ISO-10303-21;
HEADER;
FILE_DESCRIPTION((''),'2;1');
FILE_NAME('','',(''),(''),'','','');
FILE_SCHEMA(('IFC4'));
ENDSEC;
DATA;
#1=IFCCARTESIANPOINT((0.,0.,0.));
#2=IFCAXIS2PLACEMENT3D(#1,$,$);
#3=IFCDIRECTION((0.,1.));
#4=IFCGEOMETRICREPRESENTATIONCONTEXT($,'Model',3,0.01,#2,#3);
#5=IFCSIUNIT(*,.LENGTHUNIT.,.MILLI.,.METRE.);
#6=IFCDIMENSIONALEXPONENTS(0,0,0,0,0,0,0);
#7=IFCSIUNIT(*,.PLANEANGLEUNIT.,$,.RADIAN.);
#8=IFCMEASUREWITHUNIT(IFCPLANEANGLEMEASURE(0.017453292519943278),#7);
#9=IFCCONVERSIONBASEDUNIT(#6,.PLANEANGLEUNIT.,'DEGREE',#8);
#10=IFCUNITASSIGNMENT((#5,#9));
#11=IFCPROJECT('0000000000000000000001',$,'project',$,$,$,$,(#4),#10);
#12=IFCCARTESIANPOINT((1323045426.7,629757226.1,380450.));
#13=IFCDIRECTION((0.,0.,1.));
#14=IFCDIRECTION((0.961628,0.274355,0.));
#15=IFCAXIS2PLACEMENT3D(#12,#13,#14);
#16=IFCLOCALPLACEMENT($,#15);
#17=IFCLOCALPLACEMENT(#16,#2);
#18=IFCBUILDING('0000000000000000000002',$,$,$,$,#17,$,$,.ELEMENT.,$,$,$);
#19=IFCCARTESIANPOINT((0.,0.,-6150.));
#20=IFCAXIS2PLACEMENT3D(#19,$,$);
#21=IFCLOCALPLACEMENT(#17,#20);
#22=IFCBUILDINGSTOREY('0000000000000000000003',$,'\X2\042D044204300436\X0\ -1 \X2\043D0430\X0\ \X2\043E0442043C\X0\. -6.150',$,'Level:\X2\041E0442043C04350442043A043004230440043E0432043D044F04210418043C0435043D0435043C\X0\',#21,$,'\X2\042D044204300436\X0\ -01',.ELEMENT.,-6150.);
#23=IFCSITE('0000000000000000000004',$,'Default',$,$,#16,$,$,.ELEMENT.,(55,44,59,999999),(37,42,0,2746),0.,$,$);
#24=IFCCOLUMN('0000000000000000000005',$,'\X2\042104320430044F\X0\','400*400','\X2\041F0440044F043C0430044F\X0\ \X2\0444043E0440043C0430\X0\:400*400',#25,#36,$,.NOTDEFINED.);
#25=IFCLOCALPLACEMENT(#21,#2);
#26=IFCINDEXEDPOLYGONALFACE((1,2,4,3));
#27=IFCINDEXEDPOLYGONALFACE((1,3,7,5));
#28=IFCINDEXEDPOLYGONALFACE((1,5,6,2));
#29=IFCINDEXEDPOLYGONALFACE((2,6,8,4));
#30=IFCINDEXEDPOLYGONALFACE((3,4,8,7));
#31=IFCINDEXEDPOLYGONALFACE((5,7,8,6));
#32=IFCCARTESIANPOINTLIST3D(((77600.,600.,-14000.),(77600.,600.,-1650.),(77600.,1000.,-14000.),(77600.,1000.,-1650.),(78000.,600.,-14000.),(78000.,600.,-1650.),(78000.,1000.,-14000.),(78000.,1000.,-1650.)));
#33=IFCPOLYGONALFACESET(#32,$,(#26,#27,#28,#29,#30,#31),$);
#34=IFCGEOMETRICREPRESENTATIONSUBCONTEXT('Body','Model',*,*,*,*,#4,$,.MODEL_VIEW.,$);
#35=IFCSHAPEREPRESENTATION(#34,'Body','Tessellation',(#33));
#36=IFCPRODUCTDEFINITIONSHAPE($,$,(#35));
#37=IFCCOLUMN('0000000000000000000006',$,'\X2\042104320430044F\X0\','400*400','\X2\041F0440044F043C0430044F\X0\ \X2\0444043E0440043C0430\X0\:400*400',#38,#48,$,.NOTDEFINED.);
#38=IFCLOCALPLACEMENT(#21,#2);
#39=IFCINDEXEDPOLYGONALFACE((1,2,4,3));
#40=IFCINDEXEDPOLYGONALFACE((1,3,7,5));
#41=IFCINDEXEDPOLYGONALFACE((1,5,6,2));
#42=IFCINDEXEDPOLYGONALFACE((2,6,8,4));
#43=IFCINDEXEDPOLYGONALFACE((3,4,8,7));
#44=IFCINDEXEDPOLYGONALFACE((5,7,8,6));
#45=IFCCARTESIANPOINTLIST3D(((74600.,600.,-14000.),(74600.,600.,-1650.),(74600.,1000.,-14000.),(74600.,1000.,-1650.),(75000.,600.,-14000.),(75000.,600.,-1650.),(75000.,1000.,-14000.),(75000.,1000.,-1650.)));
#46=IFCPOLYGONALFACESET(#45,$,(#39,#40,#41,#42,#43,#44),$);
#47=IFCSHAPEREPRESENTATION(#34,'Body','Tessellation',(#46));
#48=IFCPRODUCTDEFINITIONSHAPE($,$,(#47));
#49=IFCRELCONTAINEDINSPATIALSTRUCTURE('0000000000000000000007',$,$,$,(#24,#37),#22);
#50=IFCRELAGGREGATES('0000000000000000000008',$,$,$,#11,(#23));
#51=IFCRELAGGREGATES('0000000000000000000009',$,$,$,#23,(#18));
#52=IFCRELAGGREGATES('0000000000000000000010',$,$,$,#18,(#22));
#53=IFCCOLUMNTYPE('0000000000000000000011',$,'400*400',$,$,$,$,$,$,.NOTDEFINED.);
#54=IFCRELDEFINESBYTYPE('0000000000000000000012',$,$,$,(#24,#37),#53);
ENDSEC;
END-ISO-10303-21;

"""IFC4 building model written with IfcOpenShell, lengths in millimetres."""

from ifc_helpers import new_model, entity, si_unit, converted_unit, direction, frame, origin, place, context, subcontext, project, spatial, indexed_curve, outline, extrude, type_object, element, save


model = new_model("IFC4")

# Units and contexts
model_context = context("Model", 3, precision=0.01, world=origin(), true_north=direction((0.0, 1.0)))
body_context = subcontext(model_context, "Body", "Model", "MODEL_VIEW")
ifc_project = project(units=[si_unit("LENGTHUNIT", "METRE", prefix="MILLI"), converted_unit("PLANEANGLEUNIT", "DEGREE", entity("IfcPlaneAngleMeasure", 0.017453292519943278), si_unit("PLANEANGLEUNIT", "RADIAN"), dimensions=[0, 0, 0, 0, 0, 0, 0])], contexts=[model_context])

# Site, building, storey
site_placement = place(None, frame((1323045426.7, 629757226.1, 380450.0), z_axis=(0.0, 0.0, 1.0), x_axis=(0.961628, 0.274355, 0.0)))
site = spatial("IfcSite", under=ifc_project, at=site_placement, Name="Default", CompositionType="ELEMENT", RefLatitude=(55, 44, 59, 999999), RefLongitude=(37, 42, 0, 2746), RefElevation=0.0)
building_placement = place(site_placement, origin())
building = spatial("IfcBuilding", under=site, at=building_placement, CompositionType="ELEMENT")
storey_placement = place(building_placement, frame((0.0, 0.0, -6150.0)))
storey = spatial("IfcBuildingStorey", under=building, at=storey_placement, Name="Этаж -1 на отм. -6.150", ObjectType="Level:ОтметкаУровняСИменем", LongName="Этаж -01", CompositionType="ELEMENT", Elevation=-6150.0)

# Columns
column_type = type_object("IfcColumnType", Name="400*400", PredefinedType="NOTDEFINED")
column_1_placement = place(storey_placement, origin())
element("IfcColumn", 1, at=column_1_placement, inside=storey, type_object=column_type, Name="Свая", Description="400*400", ObjectType="Прямая форма:400*400", PredefinedType="NOTDEFINED", context=body_context, shape_type="SweptSolid", body=[
    extrude(outline(indexed_curve([(-200.0, -200.0), (200.0, -200.0), (200.0, 200.0), (-200.0, 200.0), (-200.0, -200.0)], self_intersect=False)), frame((77800.0, 800.0, -14000.0), z_axis=(0.0, 0.0, 1.0), x_axis=(0.0, 1.0, 0.0)), (0.0, 0.0, 1.0), 12350.0),
])
column_2_placement = place(storey_placement, origin())
element("IfcColumn", 2, at=column_2_placement, inside=storey, type_object=column_type, Name="Свая", Description="400*400", ObjectType="Прямая форма:400*400", PredefinedType="NOTDEFINED", context=body_context, shape_type="SweptSolid", body=[
    extrude(outline(indexed_curve([(-200.0, -200.0), (200.0, -200.0), (200.0, 200.0), (-200.0, 200.0), (-200.0, -200.0)], self_intersect=False)), frame((74800.0, 800.0, -14000.0), z_axis=(0.0, 0.0, 1.0), x_axis=(0.0, 1.0, 0.0)), (0.0, 0.0, 1.0), 12350.0),
])

save(model, "model.ifc")
